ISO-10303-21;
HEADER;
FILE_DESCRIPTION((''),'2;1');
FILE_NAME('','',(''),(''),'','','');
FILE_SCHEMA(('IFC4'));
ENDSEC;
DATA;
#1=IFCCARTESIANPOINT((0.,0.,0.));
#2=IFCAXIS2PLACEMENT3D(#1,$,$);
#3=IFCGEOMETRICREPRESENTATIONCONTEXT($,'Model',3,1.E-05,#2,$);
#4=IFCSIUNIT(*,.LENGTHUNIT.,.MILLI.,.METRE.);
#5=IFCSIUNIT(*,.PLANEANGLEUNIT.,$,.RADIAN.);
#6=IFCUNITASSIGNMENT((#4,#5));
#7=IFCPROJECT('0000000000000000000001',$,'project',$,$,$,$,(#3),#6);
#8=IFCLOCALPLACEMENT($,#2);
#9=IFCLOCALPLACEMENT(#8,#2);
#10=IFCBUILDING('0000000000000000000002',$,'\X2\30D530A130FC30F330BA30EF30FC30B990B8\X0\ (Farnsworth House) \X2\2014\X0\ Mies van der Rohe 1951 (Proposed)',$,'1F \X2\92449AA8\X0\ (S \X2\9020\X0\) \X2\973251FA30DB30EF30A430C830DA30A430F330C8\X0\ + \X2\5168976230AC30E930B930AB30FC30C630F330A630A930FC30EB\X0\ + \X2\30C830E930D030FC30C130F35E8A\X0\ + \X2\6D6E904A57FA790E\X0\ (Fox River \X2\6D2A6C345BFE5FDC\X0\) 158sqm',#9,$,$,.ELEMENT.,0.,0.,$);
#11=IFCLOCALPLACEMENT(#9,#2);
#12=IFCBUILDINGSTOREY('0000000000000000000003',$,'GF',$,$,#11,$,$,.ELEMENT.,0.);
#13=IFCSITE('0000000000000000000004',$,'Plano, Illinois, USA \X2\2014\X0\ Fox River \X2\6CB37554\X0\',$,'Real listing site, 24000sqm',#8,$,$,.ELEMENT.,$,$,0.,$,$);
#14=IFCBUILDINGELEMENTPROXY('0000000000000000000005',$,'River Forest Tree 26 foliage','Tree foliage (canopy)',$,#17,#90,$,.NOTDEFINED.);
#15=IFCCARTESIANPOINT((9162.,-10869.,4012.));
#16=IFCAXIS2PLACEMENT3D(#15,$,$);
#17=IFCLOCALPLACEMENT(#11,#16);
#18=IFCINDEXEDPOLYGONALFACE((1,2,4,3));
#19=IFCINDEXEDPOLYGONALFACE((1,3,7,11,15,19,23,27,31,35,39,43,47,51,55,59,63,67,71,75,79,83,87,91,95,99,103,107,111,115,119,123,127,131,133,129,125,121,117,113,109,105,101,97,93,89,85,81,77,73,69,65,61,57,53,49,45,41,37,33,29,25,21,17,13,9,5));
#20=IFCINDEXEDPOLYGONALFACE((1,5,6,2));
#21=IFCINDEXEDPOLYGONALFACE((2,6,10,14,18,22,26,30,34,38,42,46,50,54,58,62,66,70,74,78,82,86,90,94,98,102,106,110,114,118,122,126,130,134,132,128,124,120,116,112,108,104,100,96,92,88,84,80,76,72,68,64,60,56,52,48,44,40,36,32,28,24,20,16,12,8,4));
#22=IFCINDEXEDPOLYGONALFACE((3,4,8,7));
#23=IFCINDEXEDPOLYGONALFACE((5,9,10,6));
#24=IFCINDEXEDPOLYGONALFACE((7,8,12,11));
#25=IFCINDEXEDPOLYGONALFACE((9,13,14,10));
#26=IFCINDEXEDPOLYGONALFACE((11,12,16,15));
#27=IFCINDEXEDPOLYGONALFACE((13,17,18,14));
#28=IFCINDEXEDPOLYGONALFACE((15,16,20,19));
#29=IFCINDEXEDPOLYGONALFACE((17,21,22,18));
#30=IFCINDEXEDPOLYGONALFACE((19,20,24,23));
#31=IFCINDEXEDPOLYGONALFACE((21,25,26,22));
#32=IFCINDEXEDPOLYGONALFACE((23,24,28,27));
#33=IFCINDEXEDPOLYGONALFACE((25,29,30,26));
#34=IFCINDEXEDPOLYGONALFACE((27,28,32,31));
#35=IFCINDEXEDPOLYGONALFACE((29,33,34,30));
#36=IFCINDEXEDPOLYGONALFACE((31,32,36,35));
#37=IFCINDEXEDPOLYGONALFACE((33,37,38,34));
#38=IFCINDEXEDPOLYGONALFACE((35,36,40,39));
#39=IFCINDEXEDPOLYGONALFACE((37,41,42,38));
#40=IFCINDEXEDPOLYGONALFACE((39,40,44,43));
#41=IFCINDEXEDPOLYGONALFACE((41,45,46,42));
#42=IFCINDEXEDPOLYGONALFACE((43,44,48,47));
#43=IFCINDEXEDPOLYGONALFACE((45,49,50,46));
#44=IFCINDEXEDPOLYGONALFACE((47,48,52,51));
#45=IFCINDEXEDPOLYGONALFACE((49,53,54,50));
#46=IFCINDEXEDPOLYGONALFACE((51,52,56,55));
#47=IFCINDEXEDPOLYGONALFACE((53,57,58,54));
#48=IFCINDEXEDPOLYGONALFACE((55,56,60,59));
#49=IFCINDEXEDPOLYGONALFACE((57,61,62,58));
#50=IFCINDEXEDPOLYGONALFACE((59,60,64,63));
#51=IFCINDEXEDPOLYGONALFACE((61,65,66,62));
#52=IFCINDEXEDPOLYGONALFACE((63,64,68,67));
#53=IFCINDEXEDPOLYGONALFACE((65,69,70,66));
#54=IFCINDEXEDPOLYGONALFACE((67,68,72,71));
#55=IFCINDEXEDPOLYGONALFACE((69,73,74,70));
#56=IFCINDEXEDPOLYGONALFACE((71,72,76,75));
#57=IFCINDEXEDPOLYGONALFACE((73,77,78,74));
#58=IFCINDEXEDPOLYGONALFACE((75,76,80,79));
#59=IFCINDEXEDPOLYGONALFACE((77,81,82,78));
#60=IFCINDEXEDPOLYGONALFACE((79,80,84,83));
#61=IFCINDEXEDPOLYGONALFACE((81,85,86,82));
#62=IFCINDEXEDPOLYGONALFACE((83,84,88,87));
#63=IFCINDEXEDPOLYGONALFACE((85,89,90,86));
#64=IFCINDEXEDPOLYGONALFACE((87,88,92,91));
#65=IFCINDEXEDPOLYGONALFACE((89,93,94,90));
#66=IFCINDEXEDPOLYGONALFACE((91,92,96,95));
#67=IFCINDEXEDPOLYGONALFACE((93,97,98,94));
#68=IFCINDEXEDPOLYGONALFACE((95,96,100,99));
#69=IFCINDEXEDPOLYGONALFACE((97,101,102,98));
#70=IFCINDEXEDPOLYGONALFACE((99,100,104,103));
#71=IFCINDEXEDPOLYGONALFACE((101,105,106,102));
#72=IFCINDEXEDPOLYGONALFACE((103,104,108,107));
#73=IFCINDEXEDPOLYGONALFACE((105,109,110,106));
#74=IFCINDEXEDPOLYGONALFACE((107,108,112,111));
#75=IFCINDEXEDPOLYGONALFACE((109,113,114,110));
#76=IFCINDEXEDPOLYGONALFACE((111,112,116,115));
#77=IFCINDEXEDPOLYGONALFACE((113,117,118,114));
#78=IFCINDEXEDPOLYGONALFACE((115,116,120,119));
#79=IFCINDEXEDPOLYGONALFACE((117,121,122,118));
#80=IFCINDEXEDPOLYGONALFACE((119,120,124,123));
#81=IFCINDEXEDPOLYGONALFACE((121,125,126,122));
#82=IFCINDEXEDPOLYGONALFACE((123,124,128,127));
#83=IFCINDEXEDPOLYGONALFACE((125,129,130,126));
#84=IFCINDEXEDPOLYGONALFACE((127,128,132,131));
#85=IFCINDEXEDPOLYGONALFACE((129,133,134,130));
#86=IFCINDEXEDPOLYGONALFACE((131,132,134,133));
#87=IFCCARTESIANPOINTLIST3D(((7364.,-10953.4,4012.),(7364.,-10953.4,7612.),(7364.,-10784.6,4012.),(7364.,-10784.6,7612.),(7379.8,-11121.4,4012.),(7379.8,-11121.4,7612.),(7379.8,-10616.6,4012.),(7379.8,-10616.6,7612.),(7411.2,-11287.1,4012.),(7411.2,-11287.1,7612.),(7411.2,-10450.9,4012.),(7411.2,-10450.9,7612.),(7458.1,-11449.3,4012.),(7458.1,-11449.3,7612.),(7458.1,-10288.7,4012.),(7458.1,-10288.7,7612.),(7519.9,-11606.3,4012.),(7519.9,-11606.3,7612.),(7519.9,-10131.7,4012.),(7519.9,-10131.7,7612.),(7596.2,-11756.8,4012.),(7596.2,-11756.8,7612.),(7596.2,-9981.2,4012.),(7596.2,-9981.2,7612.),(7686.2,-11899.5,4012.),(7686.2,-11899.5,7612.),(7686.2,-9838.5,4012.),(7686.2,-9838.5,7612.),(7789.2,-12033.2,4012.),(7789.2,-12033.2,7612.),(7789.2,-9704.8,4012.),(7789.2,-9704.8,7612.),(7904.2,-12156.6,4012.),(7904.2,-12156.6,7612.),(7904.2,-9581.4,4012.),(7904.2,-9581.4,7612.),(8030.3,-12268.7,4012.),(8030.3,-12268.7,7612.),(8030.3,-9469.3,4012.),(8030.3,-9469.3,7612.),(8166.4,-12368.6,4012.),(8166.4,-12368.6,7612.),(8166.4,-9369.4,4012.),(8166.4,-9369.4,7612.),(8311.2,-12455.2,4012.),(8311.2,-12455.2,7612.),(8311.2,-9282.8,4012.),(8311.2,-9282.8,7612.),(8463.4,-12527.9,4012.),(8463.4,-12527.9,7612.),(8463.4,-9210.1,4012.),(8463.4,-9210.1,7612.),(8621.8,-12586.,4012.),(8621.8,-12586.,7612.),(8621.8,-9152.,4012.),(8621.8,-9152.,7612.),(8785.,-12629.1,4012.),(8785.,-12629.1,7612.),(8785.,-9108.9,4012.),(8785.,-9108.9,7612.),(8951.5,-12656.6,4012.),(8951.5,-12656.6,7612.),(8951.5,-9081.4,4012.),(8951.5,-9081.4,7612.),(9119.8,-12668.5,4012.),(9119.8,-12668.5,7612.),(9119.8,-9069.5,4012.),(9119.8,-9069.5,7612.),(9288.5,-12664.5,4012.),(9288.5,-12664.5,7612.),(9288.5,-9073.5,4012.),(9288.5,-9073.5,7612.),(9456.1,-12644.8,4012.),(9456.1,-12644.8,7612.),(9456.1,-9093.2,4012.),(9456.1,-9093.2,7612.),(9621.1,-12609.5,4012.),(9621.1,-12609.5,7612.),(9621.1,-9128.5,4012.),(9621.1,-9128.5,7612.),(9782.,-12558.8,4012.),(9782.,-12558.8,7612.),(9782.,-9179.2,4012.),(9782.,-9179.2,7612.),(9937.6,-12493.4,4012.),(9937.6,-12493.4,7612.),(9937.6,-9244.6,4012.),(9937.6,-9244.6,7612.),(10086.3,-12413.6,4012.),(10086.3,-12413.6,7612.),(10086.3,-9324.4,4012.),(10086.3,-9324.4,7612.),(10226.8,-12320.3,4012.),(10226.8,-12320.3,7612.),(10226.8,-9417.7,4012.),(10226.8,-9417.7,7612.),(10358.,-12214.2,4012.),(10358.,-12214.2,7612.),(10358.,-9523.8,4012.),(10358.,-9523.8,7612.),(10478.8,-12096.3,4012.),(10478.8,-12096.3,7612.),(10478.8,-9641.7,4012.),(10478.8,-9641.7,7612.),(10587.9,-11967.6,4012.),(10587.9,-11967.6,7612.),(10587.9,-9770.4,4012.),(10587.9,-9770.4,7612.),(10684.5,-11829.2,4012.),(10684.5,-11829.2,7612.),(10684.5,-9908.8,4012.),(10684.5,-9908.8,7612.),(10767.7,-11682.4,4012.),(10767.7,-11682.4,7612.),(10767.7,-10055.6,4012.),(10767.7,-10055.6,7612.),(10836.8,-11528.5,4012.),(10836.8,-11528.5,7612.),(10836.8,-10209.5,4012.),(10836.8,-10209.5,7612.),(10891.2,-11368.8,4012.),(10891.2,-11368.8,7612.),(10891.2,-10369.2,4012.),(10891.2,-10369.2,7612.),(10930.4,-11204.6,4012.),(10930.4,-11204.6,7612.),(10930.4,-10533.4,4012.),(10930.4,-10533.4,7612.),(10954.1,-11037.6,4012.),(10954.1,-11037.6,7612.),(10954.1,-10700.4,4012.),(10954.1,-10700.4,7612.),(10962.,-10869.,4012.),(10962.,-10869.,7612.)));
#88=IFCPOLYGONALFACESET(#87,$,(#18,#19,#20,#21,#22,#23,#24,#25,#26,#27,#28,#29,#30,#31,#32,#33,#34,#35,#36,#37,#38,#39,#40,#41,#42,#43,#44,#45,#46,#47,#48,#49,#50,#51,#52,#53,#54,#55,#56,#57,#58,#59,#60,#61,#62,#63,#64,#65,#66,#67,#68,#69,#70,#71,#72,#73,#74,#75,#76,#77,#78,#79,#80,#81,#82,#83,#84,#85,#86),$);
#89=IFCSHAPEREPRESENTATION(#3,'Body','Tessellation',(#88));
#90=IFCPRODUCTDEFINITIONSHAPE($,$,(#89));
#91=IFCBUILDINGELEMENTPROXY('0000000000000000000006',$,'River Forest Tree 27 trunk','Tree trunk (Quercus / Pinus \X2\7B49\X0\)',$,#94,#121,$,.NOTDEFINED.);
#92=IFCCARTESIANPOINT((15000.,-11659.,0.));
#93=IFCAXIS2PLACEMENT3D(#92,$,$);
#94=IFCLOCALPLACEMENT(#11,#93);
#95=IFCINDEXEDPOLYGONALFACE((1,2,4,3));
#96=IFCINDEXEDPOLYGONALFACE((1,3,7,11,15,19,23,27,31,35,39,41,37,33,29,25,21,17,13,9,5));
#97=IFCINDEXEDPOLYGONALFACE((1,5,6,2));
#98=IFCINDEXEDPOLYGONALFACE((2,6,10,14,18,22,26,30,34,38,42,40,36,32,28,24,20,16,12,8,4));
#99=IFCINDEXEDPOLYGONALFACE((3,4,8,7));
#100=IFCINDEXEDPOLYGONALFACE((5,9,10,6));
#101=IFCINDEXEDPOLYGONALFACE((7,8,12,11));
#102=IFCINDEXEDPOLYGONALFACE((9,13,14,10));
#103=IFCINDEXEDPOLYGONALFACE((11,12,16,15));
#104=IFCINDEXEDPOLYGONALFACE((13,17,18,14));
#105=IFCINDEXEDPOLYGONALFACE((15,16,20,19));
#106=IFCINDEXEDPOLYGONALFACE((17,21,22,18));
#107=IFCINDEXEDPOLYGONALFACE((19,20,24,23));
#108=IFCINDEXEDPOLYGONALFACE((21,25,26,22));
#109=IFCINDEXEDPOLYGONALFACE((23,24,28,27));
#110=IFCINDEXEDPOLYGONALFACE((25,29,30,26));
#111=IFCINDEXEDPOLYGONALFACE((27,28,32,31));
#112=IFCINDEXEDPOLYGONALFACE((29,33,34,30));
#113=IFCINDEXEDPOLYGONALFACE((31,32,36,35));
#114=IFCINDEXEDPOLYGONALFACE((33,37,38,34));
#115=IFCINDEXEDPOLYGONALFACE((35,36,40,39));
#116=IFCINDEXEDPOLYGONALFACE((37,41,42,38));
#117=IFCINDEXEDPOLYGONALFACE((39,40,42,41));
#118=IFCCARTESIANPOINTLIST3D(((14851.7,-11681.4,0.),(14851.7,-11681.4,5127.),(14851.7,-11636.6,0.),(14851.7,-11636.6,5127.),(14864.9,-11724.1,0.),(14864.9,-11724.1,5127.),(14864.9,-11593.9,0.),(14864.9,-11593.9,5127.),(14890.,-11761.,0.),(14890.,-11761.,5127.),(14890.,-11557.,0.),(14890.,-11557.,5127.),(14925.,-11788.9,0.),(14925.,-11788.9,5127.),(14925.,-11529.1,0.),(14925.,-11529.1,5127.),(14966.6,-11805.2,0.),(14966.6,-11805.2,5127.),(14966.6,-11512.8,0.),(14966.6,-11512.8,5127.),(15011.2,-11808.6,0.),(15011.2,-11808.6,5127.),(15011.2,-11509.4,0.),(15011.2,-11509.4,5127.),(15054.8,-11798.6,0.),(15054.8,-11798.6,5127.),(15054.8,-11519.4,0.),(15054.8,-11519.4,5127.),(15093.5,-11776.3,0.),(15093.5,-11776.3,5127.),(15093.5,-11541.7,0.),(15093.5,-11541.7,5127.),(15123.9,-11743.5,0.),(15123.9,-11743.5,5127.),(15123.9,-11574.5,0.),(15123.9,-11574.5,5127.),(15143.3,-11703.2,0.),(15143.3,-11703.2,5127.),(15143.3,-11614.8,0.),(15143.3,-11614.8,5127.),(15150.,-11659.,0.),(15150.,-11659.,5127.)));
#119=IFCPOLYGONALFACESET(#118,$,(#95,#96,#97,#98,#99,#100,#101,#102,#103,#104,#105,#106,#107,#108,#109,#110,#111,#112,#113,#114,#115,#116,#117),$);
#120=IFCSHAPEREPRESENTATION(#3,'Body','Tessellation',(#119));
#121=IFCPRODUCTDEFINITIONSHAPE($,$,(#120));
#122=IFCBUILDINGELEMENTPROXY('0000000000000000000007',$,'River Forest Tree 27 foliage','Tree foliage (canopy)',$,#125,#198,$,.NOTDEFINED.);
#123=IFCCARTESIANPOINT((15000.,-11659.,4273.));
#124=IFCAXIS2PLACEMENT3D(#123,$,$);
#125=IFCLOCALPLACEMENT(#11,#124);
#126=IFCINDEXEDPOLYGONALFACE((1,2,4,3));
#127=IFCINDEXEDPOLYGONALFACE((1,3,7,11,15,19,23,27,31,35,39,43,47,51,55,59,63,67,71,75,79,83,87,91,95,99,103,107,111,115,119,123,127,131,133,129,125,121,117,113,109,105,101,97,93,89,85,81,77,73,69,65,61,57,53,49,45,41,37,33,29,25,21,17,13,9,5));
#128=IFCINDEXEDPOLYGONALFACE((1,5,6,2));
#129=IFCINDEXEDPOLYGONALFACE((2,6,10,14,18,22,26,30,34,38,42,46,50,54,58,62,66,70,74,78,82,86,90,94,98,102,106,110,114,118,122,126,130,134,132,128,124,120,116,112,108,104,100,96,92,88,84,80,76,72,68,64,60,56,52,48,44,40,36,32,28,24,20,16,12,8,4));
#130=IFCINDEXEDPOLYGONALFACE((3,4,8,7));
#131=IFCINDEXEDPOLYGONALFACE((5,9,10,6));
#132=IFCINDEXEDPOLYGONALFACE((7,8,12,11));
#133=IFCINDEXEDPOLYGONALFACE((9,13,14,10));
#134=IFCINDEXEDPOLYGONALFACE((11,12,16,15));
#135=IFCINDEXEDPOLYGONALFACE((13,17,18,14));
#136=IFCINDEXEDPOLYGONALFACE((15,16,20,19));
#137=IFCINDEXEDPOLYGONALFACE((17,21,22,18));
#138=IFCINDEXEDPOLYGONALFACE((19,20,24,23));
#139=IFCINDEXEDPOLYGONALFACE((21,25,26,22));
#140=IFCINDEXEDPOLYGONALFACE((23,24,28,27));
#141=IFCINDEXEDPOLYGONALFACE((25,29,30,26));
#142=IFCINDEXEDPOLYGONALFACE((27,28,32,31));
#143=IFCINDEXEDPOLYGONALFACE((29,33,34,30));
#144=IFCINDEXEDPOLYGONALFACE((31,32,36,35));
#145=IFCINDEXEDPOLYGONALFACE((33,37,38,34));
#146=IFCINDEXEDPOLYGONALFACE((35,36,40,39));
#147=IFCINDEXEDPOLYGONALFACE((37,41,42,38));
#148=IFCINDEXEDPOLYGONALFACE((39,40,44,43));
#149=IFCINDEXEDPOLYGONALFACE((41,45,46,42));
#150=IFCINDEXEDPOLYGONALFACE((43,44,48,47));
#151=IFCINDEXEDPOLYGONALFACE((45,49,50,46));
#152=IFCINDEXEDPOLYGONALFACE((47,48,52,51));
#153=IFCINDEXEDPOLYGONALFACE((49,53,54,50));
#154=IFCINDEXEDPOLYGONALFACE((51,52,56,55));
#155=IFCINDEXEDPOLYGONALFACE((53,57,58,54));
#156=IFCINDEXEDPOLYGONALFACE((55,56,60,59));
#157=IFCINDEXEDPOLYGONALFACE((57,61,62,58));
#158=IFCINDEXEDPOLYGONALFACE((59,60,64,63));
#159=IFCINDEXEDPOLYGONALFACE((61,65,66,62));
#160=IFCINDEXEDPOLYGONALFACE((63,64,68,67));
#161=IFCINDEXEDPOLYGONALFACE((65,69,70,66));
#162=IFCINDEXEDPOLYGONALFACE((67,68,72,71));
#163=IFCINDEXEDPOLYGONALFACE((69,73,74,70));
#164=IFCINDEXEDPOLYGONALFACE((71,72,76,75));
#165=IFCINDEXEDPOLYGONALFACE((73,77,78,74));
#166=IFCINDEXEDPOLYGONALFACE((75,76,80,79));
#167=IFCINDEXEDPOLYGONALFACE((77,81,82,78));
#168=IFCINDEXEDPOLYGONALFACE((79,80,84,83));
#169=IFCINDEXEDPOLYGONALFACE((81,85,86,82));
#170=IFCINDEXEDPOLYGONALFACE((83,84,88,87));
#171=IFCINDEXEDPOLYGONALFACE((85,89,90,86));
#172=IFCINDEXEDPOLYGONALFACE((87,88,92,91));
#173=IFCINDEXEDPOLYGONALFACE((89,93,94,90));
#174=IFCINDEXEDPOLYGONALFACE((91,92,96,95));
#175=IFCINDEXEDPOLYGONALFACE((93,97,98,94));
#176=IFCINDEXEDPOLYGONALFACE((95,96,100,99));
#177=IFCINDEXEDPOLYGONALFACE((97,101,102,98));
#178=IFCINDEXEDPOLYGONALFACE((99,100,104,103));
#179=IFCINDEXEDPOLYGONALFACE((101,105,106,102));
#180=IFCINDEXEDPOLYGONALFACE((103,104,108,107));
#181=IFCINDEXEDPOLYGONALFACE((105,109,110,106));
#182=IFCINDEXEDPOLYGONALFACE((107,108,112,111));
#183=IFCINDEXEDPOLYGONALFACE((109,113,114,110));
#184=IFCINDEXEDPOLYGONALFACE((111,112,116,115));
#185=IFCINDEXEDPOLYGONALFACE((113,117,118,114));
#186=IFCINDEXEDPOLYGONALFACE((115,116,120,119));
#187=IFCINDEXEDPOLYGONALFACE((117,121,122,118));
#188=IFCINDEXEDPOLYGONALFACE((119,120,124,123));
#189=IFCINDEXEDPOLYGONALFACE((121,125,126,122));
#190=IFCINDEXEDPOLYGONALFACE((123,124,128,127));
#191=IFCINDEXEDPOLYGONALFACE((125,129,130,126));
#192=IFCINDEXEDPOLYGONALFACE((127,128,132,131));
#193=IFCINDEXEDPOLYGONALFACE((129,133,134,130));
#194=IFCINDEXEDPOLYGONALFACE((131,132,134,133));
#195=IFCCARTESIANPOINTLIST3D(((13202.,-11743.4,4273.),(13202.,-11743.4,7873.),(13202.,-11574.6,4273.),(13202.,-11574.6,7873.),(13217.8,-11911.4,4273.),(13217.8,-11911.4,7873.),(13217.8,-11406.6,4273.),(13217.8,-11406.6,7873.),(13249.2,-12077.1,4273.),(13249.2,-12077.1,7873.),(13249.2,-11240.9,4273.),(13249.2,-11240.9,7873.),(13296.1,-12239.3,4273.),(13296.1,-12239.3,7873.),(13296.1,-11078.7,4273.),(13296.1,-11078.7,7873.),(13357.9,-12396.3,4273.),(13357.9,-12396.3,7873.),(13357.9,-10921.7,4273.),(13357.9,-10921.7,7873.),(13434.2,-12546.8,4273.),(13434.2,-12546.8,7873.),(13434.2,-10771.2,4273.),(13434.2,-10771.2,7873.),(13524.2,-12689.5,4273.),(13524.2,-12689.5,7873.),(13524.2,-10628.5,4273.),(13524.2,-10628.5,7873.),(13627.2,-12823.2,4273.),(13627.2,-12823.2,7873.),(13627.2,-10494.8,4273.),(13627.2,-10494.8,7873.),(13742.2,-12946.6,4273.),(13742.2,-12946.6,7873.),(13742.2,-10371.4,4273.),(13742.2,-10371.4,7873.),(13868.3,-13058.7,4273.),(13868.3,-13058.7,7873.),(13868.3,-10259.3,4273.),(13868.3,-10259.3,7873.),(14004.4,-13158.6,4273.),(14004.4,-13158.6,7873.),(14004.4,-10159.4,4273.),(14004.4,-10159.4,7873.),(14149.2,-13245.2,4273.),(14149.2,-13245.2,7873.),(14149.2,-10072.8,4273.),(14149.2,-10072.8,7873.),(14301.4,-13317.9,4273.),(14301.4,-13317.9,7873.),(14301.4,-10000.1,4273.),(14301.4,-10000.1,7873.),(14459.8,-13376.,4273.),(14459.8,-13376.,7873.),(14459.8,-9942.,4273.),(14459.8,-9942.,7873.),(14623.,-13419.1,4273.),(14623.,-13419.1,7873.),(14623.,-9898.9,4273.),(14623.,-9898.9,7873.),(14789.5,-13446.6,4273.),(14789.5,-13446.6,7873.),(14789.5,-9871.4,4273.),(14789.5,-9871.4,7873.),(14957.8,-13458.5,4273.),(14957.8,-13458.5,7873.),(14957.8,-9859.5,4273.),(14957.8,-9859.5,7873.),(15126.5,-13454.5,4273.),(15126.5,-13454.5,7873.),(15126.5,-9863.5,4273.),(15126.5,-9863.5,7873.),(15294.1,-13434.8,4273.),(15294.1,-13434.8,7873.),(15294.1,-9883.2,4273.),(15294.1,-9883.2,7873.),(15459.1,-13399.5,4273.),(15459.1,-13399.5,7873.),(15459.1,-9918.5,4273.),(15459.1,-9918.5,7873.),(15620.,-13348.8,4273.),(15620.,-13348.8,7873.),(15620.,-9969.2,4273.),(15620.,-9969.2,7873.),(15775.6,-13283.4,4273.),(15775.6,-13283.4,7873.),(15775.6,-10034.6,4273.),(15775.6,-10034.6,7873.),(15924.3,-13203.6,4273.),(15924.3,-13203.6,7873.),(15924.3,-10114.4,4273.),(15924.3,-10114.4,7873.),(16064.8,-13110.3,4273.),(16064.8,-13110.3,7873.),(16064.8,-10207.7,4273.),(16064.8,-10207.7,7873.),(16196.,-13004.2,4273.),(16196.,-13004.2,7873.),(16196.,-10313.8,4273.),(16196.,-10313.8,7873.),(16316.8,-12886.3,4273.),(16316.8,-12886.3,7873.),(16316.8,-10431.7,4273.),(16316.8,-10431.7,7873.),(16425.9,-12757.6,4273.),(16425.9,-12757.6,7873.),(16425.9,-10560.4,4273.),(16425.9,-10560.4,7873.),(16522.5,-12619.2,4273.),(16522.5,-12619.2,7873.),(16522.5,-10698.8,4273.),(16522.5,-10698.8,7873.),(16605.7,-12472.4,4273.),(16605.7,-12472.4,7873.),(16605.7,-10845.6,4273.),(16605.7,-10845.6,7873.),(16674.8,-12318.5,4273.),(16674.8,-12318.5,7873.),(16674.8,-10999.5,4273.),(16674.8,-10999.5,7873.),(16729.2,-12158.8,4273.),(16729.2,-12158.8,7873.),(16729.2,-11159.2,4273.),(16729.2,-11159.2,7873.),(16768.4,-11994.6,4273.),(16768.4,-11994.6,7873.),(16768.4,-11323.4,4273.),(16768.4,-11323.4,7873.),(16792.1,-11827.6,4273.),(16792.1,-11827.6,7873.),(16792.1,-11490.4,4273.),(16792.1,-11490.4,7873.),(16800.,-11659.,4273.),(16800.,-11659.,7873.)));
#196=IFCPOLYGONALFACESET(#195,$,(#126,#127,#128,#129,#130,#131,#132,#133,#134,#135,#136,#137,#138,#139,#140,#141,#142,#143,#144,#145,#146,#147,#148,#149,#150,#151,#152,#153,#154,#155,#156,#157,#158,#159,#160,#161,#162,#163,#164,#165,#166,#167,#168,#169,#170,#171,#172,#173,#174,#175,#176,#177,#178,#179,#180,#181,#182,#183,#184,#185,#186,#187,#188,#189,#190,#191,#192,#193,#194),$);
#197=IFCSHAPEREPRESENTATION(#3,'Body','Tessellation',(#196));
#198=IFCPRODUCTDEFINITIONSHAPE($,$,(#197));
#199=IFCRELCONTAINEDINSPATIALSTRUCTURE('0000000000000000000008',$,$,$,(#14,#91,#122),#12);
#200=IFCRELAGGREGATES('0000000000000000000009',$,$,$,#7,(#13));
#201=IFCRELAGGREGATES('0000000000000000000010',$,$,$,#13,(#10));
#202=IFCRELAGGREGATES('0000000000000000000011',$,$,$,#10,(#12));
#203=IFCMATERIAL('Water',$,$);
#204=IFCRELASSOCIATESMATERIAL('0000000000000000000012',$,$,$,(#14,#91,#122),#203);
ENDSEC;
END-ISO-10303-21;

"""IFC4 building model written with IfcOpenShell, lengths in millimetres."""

from ifc_helpers import new_model, si_unit, frame, origin, origin_2d, place, context, project, spatial, circle, extrude, material, element, save


model = new_model("IFC4")

# Units and contexts
model_context = context("Model", 3, precision=1e-05, world=origin())
ifc_project = project(units=[si_unit("LENGTHUNIT", "METRE", prefix="MILLI"), si_unit("PLANEANGLEUNIT", "RADIAN")], contexts=[model_context])

# Site, building, storey
site_placement = place(None, origin())
site = spatial("IfcSite", under=ifc_project, at=site_placement, Name="Plano, Illinois, USA — Fox River 河畔", ObjectType="Real listing site, 24000sqm", CompositionType="ELEMENT", RefElevation=0.0)
building_placement = place(site_placement, origin())
building = spatial("IfcBuilding", under=site, at=building_placement, Name="ファーンズワース邸 (Farnsworth House) — Mies van der Rohe 1951 (Proposed)", ObjectType="1F 鉄骨 (S 造) 露出ホワイトペイント + 全面ガラスカーテンウォール + トラバーチン床 + 浮遊基礎 (Fox River 洪水対応) 158sqm", CompositionType="ELEMENT", ElevationOfRefHeight=0.0, ElevationOfTerrain=0.0)
storey_placement = place(building_placement, origin())
storey = spatial("IfcBuildingStorey", under=building, at=storey_placement, Name="GF", CompositionType="ELEMENT", Elevation=0.0)

# Building element proxies
ifc_material_1 = material(Name="Water")
proxy_1_placement = place(storey_placement, frame((9162.0, -10869.0, 4012.0)))
element("IfcBuildingElementProxy", 1, at=proxy_1_placement, inside=storey, material=ifc_material_1, Name="River Forest Tree 26 foliage", Description="Tree foliage (canopy)", PredefinedType="NOTDEFINED", context=model_context, shape_type="SweptSolid", body=[
    extrude(circle(Radius=1800.0, at=origin_2d()), frame((9162.0, -10869.0, 4012.0)), (0.0, 0.0, 1.0), 3600.0),
])
proxy_2_placement = place(storey_placement, frame((15000.0, -11659.0, 0.0)))
element("IfcBuildingElementProxy", 2, at=proxy_2_placement, inside=storey, material=ifc_material_1, Name="River Forest Tree 27 trunk", Description="Tree trunk (Quercus / Pinus 等)", PredefinedType="NOTDEFINED", context=model_context, shape_type="SweptSolid", body=[
    extrude(circle(Radius=150.0, at=origin_2d()), frame((15000.0, -11659.0, 0.0)), (0.0, 0.0, 1.0), 5127.0),
])
proxy_3_placement = place(storey_placement, frame((15000.0, -11659.0, 4273.0)))
element("IfcBuildingElementProxy", 3, at=proxy_3_placement, inside=storey, material=ifc_material_1, Name="River Forest Tree 27 foliage", Description="Tree foliage (canopy)", PredefinedType="NOTDEFINED", context=model_context, shape_type="SweptSolid", body=[
    extrude(circle(Radius=1800.0, at=origin_2d()), frame((15000.0, -11659.0, 4273.0)), (0.0, 0.0, 1.0), 3600.0),
])

save(model, "model.ifc")
